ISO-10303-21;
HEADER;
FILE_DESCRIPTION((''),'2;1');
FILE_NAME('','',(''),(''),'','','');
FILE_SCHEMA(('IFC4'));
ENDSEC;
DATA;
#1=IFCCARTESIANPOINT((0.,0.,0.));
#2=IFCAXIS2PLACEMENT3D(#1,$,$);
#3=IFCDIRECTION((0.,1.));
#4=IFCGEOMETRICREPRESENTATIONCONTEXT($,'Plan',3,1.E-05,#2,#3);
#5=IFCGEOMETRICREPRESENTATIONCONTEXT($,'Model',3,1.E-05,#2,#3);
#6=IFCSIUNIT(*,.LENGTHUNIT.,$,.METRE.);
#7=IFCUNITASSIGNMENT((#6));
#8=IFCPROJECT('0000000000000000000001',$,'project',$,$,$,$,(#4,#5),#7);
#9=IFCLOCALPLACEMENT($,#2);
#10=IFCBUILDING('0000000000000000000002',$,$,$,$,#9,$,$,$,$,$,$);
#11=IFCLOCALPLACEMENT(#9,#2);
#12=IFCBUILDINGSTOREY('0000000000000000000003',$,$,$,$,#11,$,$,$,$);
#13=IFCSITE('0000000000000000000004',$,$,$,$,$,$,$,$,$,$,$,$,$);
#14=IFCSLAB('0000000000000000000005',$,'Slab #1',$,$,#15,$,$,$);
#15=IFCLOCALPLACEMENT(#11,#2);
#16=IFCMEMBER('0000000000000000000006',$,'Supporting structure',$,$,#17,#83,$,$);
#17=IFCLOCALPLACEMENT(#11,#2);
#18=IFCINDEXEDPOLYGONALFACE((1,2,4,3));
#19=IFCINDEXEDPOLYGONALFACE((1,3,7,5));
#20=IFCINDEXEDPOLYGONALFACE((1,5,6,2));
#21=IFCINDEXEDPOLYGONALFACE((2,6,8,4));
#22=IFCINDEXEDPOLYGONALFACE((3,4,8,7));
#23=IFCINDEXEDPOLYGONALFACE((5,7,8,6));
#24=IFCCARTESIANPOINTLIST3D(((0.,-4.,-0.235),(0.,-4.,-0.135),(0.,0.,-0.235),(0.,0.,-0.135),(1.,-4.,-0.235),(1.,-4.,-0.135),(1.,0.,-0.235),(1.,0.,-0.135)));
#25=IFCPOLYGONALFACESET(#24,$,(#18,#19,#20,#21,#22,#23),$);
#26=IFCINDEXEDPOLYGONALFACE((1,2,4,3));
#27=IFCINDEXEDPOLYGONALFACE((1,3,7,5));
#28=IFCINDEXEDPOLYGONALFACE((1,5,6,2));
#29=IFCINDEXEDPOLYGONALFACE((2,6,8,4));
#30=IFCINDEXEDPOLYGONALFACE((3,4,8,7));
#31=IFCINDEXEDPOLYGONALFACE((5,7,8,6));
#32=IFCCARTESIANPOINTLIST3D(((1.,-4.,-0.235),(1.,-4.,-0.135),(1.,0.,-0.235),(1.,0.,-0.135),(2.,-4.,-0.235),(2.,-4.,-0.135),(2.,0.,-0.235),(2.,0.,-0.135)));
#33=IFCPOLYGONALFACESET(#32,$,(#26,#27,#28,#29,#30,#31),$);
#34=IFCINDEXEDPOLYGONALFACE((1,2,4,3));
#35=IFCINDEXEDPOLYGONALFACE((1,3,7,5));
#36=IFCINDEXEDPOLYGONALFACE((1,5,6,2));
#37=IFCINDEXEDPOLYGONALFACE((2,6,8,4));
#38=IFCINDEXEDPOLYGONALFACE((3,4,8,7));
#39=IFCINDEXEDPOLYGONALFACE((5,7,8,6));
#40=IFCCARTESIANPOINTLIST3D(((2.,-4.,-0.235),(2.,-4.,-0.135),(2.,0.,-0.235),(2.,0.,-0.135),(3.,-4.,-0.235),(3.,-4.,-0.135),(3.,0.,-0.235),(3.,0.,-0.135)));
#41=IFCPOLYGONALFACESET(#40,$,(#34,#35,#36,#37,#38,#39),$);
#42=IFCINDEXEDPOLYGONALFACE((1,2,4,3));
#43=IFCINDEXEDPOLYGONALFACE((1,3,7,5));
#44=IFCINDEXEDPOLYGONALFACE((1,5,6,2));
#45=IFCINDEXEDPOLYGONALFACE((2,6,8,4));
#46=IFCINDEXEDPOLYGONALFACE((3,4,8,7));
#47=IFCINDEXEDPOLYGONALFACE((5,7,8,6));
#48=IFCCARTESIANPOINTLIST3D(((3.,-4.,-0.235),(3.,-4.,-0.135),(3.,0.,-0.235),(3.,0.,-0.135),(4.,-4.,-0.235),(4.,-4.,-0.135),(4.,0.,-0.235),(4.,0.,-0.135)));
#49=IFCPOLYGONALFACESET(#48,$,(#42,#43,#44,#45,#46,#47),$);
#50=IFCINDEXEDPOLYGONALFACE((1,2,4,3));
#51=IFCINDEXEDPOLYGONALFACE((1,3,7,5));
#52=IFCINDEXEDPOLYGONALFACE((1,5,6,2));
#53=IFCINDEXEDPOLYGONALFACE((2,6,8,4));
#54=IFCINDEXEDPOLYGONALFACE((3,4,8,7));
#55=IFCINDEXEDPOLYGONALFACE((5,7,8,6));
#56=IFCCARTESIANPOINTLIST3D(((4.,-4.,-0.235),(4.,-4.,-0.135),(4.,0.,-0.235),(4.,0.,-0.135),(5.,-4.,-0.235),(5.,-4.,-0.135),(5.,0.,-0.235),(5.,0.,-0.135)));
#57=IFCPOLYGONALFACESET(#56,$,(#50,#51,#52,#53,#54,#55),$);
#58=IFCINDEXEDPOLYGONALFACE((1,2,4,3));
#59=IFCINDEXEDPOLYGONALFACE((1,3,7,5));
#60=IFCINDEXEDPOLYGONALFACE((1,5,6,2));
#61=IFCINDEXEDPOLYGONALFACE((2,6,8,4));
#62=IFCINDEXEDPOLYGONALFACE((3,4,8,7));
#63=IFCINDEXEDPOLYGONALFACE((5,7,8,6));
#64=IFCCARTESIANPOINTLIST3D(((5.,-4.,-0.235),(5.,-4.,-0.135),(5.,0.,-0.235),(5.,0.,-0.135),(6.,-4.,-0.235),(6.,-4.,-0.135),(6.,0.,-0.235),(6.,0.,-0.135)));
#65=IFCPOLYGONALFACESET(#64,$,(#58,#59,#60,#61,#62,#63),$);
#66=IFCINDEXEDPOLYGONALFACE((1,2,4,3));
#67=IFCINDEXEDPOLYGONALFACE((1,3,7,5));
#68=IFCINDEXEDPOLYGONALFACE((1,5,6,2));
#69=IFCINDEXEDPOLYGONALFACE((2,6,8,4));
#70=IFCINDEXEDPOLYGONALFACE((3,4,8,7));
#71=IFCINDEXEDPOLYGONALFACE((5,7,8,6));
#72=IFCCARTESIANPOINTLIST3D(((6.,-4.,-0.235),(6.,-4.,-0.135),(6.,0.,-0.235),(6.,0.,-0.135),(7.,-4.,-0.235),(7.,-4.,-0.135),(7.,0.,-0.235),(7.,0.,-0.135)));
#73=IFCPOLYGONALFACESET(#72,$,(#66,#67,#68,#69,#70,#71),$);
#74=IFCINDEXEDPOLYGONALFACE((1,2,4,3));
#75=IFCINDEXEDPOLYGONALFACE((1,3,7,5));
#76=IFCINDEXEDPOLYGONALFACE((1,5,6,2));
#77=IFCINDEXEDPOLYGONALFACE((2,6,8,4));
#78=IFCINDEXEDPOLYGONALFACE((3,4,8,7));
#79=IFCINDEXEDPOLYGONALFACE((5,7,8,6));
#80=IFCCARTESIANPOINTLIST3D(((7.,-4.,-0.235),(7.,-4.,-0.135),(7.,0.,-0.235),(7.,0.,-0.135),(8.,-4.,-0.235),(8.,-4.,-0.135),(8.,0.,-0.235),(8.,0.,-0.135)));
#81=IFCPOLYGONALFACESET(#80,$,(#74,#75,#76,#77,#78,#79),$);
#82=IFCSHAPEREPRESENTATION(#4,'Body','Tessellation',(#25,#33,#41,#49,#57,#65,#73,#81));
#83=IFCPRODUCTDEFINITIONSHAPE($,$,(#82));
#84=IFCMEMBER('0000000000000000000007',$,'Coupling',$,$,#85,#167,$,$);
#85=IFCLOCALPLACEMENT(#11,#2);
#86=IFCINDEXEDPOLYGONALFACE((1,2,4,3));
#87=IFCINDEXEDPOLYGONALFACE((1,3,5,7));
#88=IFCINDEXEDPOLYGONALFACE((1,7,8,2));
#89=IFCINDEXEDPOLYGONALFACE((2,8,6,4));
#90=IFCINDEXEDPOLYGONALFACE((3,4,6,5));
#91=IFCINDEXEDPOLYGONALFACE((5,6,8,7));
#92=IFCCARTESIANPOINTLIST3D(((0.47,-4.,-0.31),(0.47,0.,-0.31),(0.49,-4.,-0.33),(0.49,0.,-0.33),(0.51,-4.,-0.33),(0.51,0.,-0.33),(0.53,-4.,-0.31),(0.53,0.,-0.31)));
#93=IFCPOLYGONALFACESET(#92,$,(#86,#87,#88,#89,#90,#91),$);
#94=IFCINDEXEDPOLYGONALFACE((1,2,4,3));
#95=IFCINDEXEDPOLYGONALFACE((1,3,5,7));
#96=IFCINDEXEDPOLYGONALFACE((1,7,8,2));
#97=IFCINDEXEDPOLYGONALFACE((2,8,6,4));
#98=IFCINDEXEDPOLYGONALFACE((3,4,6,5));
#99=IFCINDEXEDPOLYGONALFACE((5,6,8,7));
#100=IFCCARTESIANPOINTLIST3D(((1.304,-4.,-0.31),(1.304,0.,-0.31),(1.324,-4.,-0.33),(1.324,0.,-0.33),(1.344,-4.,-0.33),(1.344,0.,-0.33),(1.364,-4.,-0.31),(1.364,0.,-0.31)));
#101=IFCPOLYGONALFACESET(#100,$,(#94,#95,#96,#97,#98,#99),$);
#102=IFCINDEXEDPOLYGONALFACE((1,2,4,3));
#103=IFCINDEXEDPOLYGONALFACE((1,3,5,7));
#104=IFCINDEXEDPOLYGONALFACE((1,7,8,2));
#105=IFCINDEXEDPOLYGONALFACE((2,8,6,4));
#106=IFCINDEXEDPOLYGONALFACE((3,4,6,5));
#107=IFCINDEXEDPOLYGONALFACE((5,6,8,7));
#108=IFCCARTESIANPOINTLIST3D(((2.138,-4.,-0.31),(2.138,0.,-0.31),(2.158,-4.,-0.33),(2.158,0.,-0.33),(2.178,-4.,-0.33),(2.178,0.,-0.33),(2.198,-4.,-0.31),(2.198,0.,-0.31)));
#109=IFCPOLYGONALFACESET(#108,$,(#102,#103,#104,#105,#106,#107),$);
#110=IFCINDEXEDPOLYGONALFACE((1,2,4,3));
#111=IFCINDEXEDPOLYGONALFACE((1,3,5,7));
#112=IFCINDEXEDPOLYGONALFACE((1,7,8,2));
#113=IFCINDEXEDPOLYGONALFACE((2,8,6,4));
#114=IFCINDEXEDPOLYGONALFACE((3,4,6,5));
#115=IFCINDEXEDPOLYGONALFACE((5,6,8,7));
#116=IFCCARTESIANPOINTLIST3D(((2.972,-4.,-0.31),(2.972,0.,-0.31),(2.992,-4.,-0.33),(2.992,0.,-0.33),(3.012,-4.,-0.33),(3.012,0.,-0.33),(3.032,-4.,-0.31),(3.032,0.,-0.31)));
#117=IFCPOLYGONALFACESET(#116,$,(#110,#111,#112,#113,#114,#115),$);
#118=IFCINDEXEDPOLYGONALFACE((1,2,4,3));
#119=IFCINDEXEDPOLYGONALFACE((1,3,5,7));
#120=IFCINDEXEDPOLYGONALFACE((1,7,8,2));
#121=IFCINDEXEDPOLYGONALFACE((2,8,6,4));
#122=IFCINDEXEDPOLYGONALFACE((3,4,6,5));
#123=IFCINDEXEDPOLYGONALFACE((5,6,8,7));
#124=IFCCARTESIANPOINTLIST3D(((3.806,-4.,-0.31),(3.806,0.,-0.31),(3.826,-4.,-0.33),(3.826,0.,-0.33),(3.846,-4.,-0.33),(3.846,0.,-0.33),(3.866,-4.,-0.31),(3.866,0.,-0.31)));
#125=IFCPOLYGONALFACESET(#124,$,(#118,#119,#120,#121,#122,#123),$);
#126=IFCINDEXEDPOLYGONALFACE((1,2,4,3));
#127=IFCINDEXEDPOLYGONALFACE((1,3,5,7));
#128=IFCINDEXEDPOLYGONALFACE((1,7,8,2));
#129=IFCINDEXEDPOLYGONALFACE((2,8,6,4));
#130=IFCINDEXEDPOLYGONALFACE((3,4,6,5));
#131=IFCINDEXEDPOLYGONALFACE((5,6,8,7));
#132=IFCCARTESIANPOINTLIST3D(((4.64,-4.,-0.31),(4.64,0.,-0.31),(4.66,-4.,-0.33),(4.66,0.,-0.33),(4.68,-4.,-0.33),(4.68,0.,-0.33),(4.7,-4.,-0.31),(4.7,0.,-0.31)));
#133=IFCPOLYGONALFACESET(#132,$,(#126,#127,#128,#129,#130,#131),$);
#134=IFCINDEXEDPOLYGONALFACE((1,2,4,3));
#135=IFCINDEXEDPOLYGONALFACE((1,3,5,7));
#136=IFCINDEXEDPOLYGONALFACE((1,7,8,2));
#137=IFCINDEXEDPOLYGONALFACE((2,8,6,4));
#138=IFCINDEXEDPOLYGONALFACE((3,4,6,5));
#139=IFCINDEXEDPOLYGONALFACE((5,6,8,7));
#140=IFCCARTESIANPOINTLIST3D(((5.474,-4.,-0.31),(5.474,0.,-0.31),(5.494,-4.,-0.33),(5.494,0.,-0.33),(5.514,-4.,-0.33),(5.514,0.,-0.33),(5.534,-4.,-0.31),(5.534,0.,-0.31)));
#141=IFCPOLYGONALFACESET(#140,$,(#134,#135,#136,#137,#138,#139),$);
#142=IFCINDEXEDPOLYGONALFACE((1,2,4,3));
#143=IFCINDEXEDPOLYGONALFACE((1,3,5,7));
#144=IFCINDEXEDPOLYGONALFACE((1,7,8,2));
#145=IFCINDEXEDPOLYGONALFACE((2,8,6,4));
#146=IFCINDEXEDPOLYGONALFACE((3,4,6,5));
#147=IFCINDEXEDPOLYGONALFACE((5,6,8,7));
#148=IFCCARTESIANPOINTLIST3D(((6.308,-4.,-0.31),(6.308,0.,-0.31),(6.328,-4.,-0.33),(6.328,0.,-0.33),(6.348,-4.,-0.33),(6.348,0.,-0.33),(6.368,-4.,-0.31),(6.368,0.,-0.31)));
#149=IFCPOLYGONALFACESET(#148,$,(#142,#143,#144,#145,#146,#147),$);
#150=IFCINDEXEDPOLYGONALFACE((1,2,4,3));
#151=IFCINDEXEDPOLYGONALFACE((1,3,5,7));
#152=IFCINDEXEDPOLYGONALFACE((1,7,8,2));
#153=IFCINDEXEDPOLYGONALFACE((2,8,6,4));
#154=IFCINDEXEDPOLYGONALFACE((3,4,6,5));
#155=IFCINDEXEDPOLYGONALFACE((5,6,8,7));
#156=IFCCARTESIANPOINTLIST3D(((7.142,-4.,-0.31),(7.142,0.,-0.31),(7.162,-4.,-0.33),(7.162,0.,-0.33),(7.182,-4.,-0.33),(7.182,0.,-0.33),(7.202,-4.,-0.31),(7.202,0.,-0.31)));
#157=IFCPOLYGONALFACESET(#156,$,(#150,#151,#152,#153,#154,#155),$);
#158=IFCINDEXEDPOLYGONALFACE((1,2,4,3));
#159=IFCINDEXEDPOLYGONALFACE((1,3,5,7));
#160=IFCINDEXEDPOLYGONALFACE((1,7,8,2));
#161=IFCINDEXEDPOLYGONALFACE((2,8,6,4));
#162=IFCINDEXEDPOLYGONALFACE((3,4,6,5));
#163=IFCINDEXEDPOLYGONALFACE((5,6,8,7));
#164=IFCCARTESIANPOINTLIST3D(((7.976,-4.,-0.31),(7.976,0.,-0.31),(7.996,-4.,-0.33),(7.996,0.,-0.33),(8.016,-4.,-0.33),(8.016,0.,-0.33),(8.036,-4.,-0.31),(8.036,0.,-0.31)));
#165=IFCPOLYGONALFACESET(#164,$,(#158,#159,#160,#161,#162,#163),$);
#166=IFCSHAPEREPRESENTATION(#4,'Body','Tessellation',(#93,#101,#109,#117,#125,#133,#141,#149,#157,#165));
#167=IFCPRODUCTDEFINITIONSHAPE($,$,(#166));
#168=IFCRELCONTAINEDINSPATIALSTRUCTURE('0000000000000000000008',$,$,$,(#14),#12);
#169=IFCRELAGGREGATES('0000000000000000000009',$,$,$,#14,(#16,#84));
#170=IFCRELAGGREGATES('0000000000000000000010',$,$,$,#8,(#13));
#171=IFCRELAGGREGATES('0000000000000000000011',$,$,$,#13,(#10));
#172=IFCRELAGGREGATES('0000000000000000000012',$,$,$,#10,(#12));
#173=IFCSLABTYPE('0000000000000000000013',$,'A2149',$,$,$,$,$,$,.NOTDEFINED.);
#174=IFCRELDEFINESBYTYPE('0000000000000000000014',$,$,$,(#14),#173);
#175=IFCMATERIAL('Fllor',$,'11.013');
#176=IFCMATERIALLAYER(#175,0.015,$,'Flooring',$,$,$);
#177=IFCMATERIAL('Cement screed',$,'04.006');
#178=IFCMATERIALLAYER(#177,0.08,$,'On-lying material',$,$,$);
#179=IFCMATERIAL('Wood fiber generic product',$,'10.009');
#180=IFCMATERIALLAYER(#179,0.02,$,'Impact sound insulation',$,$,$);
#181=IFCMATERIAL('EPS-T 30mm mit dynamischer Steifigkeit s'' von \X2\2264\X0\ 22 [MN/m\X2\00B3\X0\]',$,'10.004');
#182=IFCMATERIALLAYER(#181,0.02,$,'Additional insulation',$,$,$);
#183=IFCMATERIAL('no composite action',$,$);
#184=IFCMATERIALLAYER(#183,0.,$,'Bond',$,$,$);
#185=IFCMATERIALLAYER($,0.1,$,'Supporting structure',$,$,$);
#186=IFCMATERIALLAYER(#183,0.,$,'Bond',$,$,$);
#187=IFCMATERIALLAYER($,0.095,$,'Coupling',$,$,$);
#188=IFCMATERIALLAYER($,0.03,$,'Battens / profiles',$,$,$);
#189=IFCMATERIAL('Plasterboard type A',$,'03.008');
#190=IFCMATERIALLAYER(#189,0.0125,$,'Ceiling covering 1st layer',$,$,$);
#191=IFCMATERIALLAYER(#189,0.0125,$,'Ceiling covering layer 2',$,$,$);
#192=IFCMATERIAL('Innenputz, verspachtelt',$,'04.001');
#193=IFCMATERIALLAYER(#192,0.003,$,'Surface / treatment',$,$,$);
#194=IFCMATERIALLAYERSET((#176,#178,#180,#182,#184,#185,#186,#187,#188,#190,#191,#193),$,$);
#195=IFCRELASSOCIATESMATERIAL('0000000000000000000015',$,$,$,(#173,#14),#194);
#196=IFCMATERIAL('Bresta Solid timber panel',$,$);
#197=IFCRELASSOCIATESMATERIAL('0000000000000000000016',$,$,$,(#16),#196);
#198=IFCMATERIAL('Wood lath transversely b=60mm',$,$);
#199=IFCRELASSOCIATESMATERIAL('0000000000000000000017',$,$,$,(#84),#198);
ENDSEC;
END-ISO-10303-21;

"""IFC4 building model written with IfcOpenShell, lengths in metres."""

from ifc_helpers import new_model, si_unit, direction, frame, frame_2d, origin, place, context, project, spatial, polyline, rectangle, outline, extrude, material, layer, layer_set, type_object, element, aggregate, save


model = new_model("IFC4")

# Units and contexts
plan_context = context("Plan", 3, precision=1e-05, world=origin(), true_north=direction((0.0, 1.0)))
model_context = context("Model", 3, precision=1e-05, world=origin(), true_north=direction((0.0, 1.0)))
ifc_project = project(units=[si_unit("LENGTHUNIT", "METRE")], contexts=[plan_context, model_context])

# Site, building, storey
site = spatial("IfcSite", under=ifc_project)
building_placement = place(None, origin())
building = spatial("IfcBuilding", under=site, at=building_placement)
storey_placement = place(building_placement, origin())
storey = spatial("IfcBuildingStorey", under=building, at=storey_placement)

# Slab, members
ifc_material_1 = material(Name="Fllor", Category="11.013")
ifc_layer_1 = layer(ifc_material_1, 0.015, Name="Flooring")
ifc_material_2 = material(Name="Cement screed", Category="04.006")
ifc_layer_2 = layer(ifc_material_2, 0.08, Name="On-lying material")
ifc_material_3 = material(Name="Wood fiber generic product", Category="10.009")
ifc_layer_3 = layer(ifc_material_3, 0.02, Name="Impact sound insulation")
ifc_material_4 = material(Name="EPS-T 30mm mit dynamischer Steifigkeit s' von ≤ 22 [MN/m³]", Category="10.004")
ifc_layer_4 = layer(ifc_material_4, 0.02, Name="Additional insulation")
ifc_material_5 = material(Name="no composite action")
ifc_layer_5 = layer(ifc_material_5, 0.0, Name="Bond")
ifc_layer_6 = layer(None, 0.1, Name="Supporting structure")
ifc_layer_7 = layer(ifc_material_5, 0.0, Name="Bond")
ifc_layer_8 = layer(None, 0.095, Name="Coupling")
ifc_layer_9 = layer(None, 0.03, Name="Battens / profiles")
ifc_material_6 = material(Name="Plasterboard type A", Category="03.008")
ifc_layer_10 = layer(ifc_material_6, 0.0125, Name="Ceiling covering 1st layer")
ifc_layer_11 = layer(ifc_material_6, 0.0125, Name="Ceiling covering layer 2")
ifc_material_7 = material(Name="Innenputz, verspachtelt", Category="04.001")
ifc_layer_12 = layer(ifc_material_7, 0.003, Name="Surface / treatment")
ifc_layer_set = layer_set([ifc_layer_1, ifc_layer_2, ifc_layer_3, ifc_layer_4, ifc_layer_5, ifc_layer_6, ifc_layer_7, ifc_layer_8, ifc_layer_9, ifc_layer_10, ifc_layer_11, ifc_layer_12])
slab_type = type_object("IfcSlabType", Name="A2149", PredefinedType="NOTDEFINED", material=ifc_layer_set)
slab_placement = place(None, frame((0.0, 0.0, 0.0), z_axis=(0.0, 0.0, -1.0), x_axis=(1.0, 0.0, 0.0)))
slab = element("IfcSlab", 1, at=slab_placement, inside=storey, type_object=slab_type, material=ifc_layer_set, Name="Slab #1")
ifc_material_8 = material(Name="Bresta Solid timber panel")
member_1_placement = place(slab_placement, origin())
member_1 = element("IfcMember", 2, at=member_1_placement, material=ifc_material_8, Name="Supporting structure", context=plan_context, shape_type="SweptSolid", body=[
    extrude(rectangle(XDim=1.0, YDim=0.1, at=frame_2d((0.5, 0.05), x_axis=(1.0, 0.0))), frame((0.0, 4.0, 0.135), z_axis=(0.0, -1.0, 0.0), x_axis=(1.0, 0.0, 0.0)), (0.0, 0.0, 1.0), 4.0),
    extrude(rectangle(XDim=1.0, YDim=0.1, at=frame_2d((0.5, 0.05), x_axis=(1.0, 0.0))), frame((1.0, 4.0, 0.135), z_axis=(0.0, -1.0, 0.0), x_axis=(1.0, 0.0, 0.0)), (0.0, 0.0, 1.0), 4.0),
    extrude(rectangle(XDim=1.0, YDim=0.1, at=frame_2d((0.5, 0.05), x_axis=(1.0, 0.0))), frame((2.0, 4.0, 0.135), z_axis=(0.0, -1.0, 0.0), x_axis=(1.0, 0.0, 0.0)), (0.0, 0.0, 1.0), 4.0),
    extrude(rectangle(XDim=1.0, YDim=0.1, at=frame_2d((0.5, 0.05), x_axis=(1.0, 0.0))), frame((3.0, 4.0, 0.135), z_axis=(0.0, -1.0, 0.0), x_axis=(1.0, 0.0, 0.0)), (0.0, 0.0, 1.0), 4.0),
    extrude(rectangle(XDim=1.0, YDim=0.1, at=frame_2d((0.5, 0.05), x_axis=(1.0, 0.0))), frame((4.0, 4.0, 0.135), z_axis=(0.0, -1.0, 0.0), x_axis=(1.0, 0.0, 0.0)), (0.0, 0.0, 1.0), 4.0),
    extrude(rectangle(XDim=1.0, YDim=0.1, at=frame_2d((0.5, 0.05), x_axis=(1.0, 0.0))), frame((5.0, 4.0, 0.135), z_axis=(0.0, -1.0, 0.0), x_axis=(1.0, 0.0, 0.0)), (0.0, 0.0, 1.0), 4.0),
    extrude(rectangle(XDim=1.0, YDim=0.1, at=frame_2d((0.5, 0.05), x_axis=(1.0, 0.0))), frame((6.0, 4.0, 0.135), z_axis=(0.0, -1.0, 0.0), x_axis=(1.0, 0.0, 0.0)), (0.0, 0.0, 1.0), 4.0),
    extrude(rectangle(XDim=1.0, YDim=0.1, at=frame_2d((0.5, 0.05), x_axis=(1.0, 0.0))), frame((7.0, 4.0, 0.135), z_axis=(0.0, -1.0, 0.0), x_axis=(1.0, 0.0, 0.0)), (0.0, 0.0, 1.0), 4.0),
])
ifc_material_9 = material(Name="Wood lath transversely b=60mm")
member_2_placement = place(slab_placement, origin())
member_2 = element("IfcMember", 3, at=member_2_placement, material=ifc_material_9, Name="Coupling", context=plan_context, shape_type="SweptSolid", body=[
    extrude(outline(polyline([(0.0, 0.0), (0.06, 0.0), (0.04, 0.02), (0.02, 0.02), (0.0, 0.0)])), frame((0.47, 4.0, 0.31), z_axis=(0.0, -1.0, 0.0), x_axis=(1.0, 0.0, 0.0)), (0.0, 0.0, 1.0), 4.0),
    extrude(outline(polyline([(0.0, 0.0), (0.06, 0.0), (0.04, 0.02), (0.02, 0.02), (0.0, 0.0)])), frame((1.304, 4.0, 0.31), z_axis=(0.0, -1.0, 0.0), x_axis=(1.0, 0.0, 0.0)), (0.0, 0.0, 1.0), 4.0),
    extrude(outline(polyline([(0.0, 0.0), (0.06, 0.0), (0.04, 0.02), (0.02, 0.02), (0.0, 0.0)])), frame((2.138, 4.0, 0.31), z_axis=(0.0, -1.0, 0.0), x_axis=(1.0, 0.0, 0.0)), (0.0, 0.0, 1.0), 4.0),
    extrude(outline(polyline([(0.0, 0.0), (0.06, 0.0), (0.04, 0.02), (0.02, 0.02), (0.0, 0.0)])), frame((2.972, 4.0, 0.31), z_axis=(0.0, -1.0, 0.0), x_axis=(1.0, 0.0, 0.0)), (0.0, 0.0, 1.0), 4.0),
    extrude(outline(polyline([(0.0, 0.0), (0.06, 0.0), (0.04, 0.02), (0.02, 0.02), (0.0, 0.0)])), frame((3.806, 4.0, 0.31), z_axis=(0.0, -1.0, 0.0), x_axis=(1.0, 0.0, 0.0)), (0.0, 0.0, 1.0), 4.0),
    extrude(outline(polyline([(0.0, 0.0), (0.06, 0.0), (0.04, 0.02), (0.02, 0.02), (0.0, 0.0)])), frame((4.64, 4.0, 0.31), z_axis=(0.0, -1.0, 0.0), x_axis=(1.0, 0.0, 0.0)), (0.0, 0.0, 1.0), 4.0),
    extrude(outline(polyline([(0.0, 0.0), (0.06, 0.0), (0.04, 0.02), (0.02, 0.02), (0.0, 0.0)])), frame((5.474, 4.0, 0.31), z_axis=(0.0, -1.0, 0.0), x_axis=(1.0, 0.0, 0.0)), (0.0, 0.0, 1.0), 4.0),
    extrude(outline(polyline([(0.0, 0.0), (0.06, 0.0), (0.04, 0.02), (0.02, 0.02), (0.0, 0.0)])), frame((6.308, 4.0, 0.31), z_axis=(0.0, -1.0, 0.0), x_axis=(1.0, 0.0, 0.0)), (0.0, 0.0, 1.0), 4.0),
    extrude(outline(polyline([(0.0, 0.0), (0.06, 0.0), (0.04, 0.02), (0.02, 0.02), (0.0, 0.0)])), frame((7.142, 4.0, 0.31), z_axis=(0.0, -1.0, 0.0), x_axis=(1.0, 0.0, 0.0)), (0.0, 0.0, 1.0), 4.0),
    extrude(outline(polyline([(0.0, 0.0), (0.06, 0.0), (0.04, 0.02), (0.02, 0.02), (0.0, 0.0)])), frame((7.976, 4.0, 0.31), z_axis=(0.0, -1.0, 0.0), x_axis=(1.0, 0.0, 0.0)), (0.0, 0.0, 1.0), 4.0),
])
aggregate(slab, [member_1, member_2])

save(model, "model.ifc")
